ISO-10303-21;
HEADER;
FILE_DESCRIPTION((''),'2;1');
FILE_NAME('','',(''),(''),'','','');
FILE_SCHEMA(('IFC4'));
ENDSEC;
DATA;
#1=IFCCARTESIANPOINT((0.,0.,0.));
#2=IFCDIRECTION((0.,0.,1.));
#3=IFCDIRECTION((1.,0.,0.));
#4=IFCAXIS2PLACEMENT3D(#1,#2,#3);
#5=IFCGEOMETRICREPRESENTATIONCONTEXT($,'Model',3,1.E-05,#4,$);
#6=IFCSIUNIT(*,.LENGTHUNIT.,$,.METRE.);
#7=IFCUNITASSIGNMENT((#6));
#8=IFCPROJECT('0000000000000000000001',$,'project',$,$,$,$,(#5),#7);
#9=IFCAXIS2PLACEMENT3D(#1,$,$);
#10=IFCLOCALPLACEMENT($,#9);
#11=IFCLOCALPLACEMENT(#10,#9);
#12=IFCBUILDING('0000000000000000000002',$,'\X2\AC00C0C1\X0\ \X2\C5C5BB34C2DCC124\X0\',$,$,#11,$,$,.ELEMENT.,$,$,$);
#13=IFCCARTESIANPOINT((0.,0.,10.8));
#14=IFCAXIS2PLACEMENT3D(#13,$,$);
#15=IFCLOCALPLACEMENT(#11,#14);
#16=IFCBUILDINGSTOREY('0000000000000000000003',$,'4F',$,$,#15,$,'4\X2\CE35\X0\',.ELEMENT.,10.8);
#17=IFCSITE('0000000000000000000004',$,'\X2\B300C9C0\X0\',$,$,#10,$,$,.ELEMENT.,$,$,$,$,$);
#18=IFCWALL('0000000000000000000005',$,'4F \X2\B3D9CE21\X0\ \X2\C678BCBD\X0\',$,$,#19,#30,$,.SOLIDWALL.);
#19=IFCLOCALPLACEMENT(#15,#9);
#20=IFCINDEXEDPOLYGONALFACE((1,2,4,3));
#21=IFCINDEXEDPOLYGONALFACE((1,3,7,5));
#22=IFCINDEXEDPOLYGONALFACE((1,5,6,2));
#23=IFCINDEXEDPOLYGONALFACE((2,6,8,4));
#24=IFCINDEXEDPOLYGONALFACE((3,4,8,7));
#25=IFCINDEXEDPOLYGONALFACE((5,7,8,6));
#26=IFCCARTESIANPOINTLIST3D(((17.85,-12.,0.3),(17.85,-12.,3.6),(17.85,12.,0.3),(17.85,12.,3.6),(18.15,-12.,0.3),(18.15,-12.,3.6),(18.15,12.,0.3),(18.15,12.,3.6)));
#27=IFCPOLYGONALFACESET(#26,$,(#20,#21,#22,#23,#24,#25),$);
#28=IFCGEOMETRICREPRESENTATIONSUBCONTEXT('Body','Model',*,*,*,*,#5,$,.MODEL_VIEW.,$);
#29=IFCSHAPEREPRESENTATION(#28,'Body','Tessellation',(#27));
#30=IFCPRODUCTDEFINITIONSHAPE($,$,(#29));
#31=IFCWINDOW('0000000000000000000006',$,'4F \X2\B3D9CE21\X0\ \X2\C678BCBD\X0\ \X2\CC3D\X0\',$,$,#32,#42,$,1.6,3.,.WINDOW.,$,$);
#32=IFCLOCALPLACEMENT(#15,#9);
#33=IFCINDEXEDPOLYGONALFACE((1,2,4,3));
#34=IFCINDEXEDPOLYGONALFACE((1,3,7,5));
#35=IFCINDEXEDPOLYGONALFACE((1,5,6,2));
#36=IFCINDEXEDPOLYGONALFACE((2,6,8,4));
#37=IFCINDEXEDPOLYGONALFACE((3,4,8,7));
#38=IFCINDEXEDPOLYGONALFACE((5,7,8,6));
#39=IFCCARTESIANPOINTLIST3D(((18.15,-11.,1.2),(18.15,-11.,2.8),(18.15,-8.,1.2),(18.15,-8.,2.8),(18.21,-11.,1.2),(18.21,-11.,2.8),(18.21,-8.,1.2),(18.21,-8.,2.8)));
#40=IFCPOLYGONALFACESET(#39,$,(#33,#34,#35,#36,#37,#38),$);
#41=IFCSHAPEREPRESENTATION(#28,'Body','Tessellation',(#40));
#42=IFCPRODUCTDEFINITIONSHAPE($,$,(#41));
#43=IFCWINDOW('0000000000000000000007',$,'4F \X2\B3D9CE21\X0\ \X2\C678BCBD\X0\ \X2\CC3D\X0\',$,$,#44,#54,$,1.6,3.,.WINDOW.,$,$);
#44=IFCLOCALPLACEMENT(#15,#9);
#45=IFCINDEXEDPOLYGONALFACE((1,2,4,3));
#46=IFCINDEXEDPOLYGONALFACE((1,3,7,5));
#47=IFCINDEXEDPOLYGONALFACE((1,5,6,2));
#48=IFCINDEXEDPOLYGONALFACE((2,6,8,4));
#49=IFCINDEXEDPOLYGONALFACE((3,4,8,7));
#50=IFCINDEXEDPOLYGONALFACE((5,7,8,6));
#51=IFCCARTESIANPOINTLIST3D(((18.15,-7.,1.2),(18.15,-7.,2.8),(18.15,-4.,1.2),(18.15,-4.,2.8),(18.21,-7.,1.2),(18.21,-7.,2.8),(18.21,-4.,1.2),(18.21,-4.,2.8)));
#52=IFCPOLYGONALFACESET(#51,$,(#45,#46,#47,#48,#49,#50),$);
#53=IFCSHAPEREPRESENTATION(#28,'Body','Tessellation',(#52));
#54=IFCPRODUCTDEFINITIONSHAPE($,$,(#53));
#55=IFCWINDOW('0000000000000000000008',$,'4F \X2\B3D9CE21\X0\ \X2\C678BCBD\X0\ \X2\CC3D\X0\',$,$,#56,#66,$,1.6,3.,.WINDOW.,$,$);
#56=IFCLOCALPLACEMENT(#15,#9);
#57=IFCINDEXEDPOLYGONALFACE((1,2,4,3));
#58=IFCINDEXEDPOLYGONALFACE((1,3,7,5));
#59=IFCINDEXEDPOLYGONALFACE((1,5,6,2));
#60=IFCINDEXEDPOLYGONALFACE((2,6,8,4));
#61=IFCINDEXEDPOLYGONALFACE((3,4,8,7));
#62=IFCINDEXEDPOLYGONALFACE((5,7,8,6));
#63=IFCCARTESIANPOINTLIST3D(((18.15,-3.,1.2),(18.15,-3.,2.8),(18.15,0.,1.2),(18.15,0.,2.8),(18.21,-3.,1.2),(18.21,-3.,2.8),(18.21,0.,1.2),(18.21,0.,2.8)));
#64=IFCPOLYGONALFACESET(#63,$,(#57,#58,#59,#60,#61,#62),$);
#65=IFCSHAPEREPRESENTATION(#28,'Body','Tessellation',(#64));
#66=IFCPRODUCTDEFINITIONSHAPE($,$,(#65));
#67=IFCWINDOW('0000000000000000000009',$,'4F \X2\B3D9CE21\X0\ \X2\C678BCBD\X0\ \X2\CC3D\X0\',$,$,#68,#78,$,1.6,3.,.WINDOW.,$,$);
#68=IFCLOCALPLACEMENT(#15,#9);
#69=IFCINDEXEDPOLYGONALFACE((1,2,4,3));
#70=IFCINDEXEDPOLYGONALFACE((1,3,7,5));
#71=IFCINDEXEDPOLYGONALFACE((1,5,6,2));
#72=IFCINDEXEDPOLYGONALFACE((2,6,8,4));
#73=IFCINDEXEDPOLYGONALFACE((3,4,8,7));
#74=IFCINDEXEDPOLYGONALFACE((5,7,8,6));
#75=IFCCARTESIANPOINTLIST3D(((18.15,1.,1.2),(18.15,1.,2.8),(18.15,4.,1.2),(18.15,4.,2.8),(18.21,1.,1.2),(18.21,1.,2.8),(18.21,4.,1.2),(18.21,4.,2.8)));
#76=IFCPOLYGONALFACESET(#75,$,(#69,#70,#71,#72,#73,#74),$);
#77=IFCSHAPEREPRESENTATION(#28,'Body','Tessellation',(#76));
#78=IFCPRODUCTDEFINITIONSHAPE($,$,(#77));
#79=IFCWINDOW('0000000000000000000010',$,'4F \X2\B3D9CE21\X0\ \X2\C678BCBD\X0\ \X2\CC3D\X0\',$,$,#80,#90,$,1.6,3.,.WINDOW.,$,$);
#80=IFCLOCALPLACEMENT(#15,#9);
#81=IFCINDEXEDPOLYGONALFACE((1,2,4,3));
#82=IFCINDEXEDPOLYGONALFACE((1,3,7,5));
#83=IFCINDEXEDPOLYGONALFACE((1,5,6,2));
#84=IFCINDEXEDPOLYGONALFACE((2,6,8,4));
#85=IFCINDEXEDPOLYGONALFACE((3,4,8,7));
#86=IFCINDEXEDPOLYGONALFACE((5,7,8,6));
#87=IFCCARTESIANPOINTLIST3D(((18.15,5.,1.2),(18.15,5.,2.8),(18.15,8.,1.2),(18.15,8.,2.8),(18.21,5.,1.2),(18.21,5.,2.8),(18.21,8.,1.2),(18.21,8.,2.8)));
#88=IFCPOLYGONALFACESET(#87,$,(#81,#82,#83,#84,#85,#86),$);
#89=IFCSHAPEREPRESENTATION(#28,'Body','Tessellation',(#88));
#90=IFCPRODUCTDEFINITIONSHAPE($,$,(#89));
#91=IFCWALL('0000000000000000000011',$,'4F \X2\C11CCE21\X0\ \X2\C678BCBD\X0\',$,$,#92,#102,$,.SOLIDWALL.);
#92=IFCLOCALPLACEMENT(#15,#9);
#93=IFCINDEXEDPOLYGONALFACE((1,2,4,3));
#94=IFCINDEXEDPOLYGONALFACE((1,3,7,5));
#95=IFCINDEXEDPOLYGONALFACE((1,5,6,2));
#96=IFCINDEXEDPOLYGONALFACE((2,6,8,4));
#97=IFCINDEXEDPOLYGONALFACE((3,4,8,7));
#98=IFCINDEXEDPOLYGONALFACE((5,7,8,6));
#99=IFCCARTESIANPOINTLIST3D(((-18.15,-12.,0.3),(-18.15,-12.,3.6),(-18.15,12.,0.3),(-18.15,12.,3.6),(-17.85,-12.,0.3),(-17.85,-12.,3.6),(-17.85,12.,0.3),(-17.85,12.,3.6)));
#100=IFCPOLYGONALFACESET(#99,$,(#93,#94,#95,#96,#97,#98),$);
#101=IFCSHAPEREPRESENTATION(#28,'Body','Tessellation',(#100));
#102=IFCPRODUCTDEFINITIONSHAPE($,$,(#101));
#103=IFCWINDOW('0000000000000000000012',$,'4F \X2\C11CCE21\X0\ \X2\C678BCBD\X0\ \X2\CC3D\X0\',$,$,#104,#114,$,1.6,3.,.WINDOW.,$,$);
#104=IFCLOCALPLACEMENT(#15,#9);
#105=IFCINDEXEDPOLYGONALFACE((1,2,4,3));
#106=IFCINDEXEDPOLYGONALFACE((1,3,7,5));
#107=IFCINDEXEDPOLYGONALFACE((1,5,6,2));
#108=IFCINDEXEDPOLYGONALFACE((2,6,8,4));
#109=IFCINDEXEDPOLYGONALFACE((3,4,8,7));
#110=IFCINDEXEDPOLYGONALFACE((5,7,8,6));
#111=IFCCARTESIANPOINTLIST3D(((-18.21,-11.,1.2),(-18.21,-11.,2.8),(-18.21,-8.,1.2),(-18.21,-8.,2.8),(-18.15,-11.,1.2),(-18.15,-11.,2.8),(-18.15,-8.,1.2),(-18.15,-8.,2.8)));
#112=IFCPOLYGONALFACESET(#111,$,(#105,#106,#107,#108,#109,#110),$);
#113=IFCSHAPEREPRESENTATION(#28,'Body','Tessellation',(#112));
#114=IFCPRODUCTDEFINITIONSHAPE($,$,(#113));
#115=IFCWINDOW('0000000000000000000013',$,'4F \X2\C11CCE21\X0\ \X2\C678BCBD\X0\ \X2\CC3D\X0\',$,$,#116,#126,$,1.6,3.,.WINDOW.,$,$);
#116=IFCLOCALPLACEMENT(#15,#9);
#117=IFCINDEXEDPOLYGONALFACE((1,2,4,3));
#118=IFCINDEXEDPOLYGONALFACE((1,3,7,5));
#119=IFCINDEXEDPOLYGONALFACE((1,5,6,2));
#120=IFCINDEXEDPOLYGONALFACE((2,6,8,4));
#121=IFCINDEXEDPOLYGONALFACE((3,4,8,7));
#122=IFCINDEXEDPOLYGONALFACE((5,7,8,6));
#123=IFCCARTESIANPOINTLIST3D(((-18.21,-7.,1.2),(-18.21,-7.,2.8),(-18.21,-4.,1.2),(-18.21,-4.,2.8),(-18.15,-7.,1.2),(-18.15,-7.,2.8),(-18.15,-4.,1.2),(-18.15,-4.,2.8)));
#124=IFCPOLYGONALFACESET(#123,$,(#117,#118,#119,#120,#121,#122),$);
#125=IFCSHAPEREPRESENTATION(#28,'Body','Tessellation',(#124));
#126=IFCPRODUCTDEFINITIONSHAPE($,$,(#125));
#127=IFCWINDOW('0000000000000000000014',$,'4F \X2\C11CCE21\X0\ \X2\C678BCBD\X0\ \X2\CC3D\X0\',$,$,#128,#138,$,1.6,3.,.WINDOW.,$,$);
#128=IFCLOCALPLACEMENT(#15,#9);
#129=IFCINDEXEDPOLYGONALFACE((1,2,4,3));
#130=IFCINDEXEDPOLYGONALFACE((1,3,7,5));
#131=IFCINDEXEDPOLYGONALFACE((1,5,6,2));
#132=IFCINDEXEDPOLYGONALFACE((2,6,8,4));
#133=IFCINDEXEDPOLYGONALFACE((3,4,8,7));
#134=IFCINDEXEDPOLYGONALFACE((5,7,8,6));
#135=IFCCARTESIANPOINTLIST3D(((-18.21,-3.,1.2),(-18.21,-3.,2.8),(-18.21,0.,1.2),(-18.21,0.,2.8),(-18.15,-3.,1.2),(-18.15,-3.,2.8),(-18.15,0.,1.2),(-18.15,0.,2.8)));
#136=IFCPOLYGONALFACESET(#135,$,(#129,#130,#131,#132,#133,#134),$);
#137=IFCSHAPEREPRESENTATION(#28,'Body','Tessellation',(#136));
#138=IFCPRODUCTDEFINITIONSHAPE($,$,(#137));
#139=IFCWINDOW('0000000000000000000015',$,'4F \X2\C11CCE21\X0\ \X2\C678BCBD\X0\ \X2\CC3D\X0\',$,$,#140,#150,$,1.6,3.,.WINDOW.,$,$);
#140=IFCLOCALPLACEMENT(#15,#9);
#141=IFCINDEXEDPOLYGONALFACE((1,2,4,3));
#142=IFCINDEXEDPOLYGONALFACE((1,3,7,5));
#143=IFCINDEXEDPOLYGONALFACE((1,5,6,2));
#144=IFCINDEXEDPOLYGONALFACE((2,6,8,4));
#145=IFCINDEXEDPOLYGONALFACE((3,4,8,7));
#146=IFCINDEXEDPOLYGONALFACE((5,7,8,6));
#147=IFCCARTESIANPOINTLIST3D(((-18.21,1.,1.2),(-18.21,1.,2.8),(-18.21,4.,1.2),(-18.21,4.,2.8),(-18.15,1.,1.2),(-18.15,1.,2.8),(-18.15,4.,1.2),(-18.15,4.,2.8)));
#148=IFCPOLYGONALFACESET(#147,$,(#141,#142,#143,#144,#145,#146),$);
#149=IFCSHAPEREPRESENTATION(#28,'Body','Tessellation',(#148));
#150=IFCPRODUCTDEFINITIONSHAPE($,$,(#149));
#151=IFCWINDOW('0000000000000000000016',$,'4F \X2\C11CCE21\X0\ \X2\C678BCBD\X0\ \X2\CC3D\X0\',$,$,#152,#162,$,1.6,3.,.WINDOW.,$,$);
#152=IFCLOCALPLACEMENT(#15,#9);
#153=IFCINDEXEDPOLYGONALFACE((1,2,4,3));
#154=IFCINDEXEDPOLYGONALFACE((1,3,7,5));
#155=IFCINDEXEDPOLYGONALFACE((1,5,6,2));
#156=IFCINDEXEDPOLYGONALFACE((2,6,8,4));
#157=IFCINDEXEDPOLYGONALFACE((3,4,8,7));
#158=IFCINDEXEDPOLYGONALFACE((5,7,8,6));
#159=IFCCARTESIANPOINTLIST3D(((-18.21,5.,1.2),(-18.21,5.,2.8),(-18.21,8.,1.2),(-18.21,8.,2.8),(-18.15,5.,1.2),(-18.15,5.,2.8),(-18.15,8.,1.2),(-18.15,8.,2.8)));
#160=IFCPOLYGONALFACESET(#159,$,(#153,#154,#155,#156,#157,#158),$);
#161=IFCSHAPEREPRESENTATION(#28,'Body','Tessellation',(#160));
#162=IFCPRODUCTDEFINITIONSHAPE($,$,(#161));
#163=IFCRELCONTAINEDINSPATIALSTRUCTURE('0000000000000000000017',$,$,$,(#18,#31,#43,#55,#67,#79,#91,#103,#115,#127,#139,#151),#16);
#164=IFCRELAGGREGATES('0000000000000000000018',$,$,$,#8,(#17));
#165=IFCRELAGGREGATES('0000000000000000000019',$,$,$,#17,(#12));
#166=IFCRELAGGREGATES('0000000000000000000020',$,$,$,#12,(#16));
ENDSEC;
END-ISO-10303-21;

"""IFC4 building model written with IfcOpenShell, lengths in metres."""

from ifc_helpers import new_model, si_unit, frame, origin, origin_with_axes, origin_2d, place, context, subcontext, project, spatial, rectangle, extrude, element, save


model = new_model("IFC4")

# Units and contexts
model_context = context("Model", 3, precision=1e-05, world=origin_with_axes())
body_context = subcontext(model_context, "Body", "Model", "MODEL_VIEW")
ifc_project = project(units=[si_unit("LENGTHUNIT", "METRE")], contexts=[model_context])

# Site, building, storey
site_placement = place(None, origin())
site = spatial("IfcSite", under=ifc_project, at=site_placement, Name="대지", CompositionType="ELEMENT")
building_placement = place(site_placement, origin())
building = spatial("IfcBuilding", under=site, at=building_placement, Name="가상 업무시설", CompositionType="ELEMENT")
storey_placement = place(building_placement, frame((0.0, 0.0, 10.8)))
storey = spatial("IfcBuildingStorey", under=building, at=storey_placement, Name="4F", LongName="4층", CompositionType="ELEMENT", Elevation=10.8)

# Wall
wall_1_placement = place(storey_placement, frame((18.0, 0.0, 0.3)))
element("IfcWall", 1, at=wall_1_placement, inside=storey, Name="4F 동측 외벽", PredefinedType="SOLIDWALL", context=body_context, shape_type="SweptSolid", body=[
    extrude(rectangle(XDim=0.3, YDim=24.0, at=origin_2d()), origin_with_axes(), (0.0, 0.0, 1.0), 3.3),
])

# Windows
for number, where, name in (
    (2, (18.18, -9.5, 1.2), "4F 동측 외벽 창"),
    (3, (18.18, -5.5, 1.2), "4F 동측 외벽 창"),
    (4, (18.18, -1.5, 1.2), "4F 동측 외벽 창"),
    (5, (18.18, 2.5, 1.2), "4F 동측 외벽 창"),
    (6, (18.18, 6.5, 1.2), "4F 동측 외벽 창"),
):
    element("IfcWindow", number, at=place(storey_placement, frame(where)), inside=storey, Name=name, OverallHeight=1.6, OverallWidth=3.0, PredefinedType="WINDOW", context=body_context, shape_type="SweptSolid", body=[
        extrude(rectangle(XDim=0.06, YDim=3.0, at=origin_2d()), origin_with_axes(), (0.0, 0.0, 1.0), 1.6),
    ])

# Wall
wall_2_placement = place(storey_placement, frame((-18.0, 0.0, 0.3)))
element("IfcWall", 7, at=wall_2_placement, inside=storey, Name="4F 서측 외벽", PredefinedType="SOLIDWALL", context=body_context, shape_type="SweptSolid", body=[
    extrude(rectangle(XDim=0.3, YDim=24.0, at=origin_2d()), origin_with_axes(), (0.0, 0.0, 1.0), 3.3),
])

# Windows
for number, where, name in (
    (8, (-18.18, -9.5, 1.2), "4F 서측 외벽 창"),
    (9, (-18.18, -5.5, 1.2), "4F 서측 외벽 창"),
    (10, (-18.18, -1.5, 1.2), "4F 서측 외벽 창"),
    (11, (-18.18, 2.5, 1.2), "4F 서측 외벽 창"),
    (12, (-18.18, 6.5, 1.2), "4F 서측 외벽 창"),
):
    element("IfcWindow", number, at=place(storey_placement, frame(where)), inside=storey, Name=name, OverallHeight=1.6, OverallWidth=3.0, PredefinedType="WINDOW", context=body_context, shape_type="SweptSolid", body=[
        extrude(rectangle(XDim=0.06, YDim=3.0, at=origin_2d()), origin_with_axes(), (0.0, 0.0, 1.0), 1.6),
    ])

save(model, "model.ifc")
